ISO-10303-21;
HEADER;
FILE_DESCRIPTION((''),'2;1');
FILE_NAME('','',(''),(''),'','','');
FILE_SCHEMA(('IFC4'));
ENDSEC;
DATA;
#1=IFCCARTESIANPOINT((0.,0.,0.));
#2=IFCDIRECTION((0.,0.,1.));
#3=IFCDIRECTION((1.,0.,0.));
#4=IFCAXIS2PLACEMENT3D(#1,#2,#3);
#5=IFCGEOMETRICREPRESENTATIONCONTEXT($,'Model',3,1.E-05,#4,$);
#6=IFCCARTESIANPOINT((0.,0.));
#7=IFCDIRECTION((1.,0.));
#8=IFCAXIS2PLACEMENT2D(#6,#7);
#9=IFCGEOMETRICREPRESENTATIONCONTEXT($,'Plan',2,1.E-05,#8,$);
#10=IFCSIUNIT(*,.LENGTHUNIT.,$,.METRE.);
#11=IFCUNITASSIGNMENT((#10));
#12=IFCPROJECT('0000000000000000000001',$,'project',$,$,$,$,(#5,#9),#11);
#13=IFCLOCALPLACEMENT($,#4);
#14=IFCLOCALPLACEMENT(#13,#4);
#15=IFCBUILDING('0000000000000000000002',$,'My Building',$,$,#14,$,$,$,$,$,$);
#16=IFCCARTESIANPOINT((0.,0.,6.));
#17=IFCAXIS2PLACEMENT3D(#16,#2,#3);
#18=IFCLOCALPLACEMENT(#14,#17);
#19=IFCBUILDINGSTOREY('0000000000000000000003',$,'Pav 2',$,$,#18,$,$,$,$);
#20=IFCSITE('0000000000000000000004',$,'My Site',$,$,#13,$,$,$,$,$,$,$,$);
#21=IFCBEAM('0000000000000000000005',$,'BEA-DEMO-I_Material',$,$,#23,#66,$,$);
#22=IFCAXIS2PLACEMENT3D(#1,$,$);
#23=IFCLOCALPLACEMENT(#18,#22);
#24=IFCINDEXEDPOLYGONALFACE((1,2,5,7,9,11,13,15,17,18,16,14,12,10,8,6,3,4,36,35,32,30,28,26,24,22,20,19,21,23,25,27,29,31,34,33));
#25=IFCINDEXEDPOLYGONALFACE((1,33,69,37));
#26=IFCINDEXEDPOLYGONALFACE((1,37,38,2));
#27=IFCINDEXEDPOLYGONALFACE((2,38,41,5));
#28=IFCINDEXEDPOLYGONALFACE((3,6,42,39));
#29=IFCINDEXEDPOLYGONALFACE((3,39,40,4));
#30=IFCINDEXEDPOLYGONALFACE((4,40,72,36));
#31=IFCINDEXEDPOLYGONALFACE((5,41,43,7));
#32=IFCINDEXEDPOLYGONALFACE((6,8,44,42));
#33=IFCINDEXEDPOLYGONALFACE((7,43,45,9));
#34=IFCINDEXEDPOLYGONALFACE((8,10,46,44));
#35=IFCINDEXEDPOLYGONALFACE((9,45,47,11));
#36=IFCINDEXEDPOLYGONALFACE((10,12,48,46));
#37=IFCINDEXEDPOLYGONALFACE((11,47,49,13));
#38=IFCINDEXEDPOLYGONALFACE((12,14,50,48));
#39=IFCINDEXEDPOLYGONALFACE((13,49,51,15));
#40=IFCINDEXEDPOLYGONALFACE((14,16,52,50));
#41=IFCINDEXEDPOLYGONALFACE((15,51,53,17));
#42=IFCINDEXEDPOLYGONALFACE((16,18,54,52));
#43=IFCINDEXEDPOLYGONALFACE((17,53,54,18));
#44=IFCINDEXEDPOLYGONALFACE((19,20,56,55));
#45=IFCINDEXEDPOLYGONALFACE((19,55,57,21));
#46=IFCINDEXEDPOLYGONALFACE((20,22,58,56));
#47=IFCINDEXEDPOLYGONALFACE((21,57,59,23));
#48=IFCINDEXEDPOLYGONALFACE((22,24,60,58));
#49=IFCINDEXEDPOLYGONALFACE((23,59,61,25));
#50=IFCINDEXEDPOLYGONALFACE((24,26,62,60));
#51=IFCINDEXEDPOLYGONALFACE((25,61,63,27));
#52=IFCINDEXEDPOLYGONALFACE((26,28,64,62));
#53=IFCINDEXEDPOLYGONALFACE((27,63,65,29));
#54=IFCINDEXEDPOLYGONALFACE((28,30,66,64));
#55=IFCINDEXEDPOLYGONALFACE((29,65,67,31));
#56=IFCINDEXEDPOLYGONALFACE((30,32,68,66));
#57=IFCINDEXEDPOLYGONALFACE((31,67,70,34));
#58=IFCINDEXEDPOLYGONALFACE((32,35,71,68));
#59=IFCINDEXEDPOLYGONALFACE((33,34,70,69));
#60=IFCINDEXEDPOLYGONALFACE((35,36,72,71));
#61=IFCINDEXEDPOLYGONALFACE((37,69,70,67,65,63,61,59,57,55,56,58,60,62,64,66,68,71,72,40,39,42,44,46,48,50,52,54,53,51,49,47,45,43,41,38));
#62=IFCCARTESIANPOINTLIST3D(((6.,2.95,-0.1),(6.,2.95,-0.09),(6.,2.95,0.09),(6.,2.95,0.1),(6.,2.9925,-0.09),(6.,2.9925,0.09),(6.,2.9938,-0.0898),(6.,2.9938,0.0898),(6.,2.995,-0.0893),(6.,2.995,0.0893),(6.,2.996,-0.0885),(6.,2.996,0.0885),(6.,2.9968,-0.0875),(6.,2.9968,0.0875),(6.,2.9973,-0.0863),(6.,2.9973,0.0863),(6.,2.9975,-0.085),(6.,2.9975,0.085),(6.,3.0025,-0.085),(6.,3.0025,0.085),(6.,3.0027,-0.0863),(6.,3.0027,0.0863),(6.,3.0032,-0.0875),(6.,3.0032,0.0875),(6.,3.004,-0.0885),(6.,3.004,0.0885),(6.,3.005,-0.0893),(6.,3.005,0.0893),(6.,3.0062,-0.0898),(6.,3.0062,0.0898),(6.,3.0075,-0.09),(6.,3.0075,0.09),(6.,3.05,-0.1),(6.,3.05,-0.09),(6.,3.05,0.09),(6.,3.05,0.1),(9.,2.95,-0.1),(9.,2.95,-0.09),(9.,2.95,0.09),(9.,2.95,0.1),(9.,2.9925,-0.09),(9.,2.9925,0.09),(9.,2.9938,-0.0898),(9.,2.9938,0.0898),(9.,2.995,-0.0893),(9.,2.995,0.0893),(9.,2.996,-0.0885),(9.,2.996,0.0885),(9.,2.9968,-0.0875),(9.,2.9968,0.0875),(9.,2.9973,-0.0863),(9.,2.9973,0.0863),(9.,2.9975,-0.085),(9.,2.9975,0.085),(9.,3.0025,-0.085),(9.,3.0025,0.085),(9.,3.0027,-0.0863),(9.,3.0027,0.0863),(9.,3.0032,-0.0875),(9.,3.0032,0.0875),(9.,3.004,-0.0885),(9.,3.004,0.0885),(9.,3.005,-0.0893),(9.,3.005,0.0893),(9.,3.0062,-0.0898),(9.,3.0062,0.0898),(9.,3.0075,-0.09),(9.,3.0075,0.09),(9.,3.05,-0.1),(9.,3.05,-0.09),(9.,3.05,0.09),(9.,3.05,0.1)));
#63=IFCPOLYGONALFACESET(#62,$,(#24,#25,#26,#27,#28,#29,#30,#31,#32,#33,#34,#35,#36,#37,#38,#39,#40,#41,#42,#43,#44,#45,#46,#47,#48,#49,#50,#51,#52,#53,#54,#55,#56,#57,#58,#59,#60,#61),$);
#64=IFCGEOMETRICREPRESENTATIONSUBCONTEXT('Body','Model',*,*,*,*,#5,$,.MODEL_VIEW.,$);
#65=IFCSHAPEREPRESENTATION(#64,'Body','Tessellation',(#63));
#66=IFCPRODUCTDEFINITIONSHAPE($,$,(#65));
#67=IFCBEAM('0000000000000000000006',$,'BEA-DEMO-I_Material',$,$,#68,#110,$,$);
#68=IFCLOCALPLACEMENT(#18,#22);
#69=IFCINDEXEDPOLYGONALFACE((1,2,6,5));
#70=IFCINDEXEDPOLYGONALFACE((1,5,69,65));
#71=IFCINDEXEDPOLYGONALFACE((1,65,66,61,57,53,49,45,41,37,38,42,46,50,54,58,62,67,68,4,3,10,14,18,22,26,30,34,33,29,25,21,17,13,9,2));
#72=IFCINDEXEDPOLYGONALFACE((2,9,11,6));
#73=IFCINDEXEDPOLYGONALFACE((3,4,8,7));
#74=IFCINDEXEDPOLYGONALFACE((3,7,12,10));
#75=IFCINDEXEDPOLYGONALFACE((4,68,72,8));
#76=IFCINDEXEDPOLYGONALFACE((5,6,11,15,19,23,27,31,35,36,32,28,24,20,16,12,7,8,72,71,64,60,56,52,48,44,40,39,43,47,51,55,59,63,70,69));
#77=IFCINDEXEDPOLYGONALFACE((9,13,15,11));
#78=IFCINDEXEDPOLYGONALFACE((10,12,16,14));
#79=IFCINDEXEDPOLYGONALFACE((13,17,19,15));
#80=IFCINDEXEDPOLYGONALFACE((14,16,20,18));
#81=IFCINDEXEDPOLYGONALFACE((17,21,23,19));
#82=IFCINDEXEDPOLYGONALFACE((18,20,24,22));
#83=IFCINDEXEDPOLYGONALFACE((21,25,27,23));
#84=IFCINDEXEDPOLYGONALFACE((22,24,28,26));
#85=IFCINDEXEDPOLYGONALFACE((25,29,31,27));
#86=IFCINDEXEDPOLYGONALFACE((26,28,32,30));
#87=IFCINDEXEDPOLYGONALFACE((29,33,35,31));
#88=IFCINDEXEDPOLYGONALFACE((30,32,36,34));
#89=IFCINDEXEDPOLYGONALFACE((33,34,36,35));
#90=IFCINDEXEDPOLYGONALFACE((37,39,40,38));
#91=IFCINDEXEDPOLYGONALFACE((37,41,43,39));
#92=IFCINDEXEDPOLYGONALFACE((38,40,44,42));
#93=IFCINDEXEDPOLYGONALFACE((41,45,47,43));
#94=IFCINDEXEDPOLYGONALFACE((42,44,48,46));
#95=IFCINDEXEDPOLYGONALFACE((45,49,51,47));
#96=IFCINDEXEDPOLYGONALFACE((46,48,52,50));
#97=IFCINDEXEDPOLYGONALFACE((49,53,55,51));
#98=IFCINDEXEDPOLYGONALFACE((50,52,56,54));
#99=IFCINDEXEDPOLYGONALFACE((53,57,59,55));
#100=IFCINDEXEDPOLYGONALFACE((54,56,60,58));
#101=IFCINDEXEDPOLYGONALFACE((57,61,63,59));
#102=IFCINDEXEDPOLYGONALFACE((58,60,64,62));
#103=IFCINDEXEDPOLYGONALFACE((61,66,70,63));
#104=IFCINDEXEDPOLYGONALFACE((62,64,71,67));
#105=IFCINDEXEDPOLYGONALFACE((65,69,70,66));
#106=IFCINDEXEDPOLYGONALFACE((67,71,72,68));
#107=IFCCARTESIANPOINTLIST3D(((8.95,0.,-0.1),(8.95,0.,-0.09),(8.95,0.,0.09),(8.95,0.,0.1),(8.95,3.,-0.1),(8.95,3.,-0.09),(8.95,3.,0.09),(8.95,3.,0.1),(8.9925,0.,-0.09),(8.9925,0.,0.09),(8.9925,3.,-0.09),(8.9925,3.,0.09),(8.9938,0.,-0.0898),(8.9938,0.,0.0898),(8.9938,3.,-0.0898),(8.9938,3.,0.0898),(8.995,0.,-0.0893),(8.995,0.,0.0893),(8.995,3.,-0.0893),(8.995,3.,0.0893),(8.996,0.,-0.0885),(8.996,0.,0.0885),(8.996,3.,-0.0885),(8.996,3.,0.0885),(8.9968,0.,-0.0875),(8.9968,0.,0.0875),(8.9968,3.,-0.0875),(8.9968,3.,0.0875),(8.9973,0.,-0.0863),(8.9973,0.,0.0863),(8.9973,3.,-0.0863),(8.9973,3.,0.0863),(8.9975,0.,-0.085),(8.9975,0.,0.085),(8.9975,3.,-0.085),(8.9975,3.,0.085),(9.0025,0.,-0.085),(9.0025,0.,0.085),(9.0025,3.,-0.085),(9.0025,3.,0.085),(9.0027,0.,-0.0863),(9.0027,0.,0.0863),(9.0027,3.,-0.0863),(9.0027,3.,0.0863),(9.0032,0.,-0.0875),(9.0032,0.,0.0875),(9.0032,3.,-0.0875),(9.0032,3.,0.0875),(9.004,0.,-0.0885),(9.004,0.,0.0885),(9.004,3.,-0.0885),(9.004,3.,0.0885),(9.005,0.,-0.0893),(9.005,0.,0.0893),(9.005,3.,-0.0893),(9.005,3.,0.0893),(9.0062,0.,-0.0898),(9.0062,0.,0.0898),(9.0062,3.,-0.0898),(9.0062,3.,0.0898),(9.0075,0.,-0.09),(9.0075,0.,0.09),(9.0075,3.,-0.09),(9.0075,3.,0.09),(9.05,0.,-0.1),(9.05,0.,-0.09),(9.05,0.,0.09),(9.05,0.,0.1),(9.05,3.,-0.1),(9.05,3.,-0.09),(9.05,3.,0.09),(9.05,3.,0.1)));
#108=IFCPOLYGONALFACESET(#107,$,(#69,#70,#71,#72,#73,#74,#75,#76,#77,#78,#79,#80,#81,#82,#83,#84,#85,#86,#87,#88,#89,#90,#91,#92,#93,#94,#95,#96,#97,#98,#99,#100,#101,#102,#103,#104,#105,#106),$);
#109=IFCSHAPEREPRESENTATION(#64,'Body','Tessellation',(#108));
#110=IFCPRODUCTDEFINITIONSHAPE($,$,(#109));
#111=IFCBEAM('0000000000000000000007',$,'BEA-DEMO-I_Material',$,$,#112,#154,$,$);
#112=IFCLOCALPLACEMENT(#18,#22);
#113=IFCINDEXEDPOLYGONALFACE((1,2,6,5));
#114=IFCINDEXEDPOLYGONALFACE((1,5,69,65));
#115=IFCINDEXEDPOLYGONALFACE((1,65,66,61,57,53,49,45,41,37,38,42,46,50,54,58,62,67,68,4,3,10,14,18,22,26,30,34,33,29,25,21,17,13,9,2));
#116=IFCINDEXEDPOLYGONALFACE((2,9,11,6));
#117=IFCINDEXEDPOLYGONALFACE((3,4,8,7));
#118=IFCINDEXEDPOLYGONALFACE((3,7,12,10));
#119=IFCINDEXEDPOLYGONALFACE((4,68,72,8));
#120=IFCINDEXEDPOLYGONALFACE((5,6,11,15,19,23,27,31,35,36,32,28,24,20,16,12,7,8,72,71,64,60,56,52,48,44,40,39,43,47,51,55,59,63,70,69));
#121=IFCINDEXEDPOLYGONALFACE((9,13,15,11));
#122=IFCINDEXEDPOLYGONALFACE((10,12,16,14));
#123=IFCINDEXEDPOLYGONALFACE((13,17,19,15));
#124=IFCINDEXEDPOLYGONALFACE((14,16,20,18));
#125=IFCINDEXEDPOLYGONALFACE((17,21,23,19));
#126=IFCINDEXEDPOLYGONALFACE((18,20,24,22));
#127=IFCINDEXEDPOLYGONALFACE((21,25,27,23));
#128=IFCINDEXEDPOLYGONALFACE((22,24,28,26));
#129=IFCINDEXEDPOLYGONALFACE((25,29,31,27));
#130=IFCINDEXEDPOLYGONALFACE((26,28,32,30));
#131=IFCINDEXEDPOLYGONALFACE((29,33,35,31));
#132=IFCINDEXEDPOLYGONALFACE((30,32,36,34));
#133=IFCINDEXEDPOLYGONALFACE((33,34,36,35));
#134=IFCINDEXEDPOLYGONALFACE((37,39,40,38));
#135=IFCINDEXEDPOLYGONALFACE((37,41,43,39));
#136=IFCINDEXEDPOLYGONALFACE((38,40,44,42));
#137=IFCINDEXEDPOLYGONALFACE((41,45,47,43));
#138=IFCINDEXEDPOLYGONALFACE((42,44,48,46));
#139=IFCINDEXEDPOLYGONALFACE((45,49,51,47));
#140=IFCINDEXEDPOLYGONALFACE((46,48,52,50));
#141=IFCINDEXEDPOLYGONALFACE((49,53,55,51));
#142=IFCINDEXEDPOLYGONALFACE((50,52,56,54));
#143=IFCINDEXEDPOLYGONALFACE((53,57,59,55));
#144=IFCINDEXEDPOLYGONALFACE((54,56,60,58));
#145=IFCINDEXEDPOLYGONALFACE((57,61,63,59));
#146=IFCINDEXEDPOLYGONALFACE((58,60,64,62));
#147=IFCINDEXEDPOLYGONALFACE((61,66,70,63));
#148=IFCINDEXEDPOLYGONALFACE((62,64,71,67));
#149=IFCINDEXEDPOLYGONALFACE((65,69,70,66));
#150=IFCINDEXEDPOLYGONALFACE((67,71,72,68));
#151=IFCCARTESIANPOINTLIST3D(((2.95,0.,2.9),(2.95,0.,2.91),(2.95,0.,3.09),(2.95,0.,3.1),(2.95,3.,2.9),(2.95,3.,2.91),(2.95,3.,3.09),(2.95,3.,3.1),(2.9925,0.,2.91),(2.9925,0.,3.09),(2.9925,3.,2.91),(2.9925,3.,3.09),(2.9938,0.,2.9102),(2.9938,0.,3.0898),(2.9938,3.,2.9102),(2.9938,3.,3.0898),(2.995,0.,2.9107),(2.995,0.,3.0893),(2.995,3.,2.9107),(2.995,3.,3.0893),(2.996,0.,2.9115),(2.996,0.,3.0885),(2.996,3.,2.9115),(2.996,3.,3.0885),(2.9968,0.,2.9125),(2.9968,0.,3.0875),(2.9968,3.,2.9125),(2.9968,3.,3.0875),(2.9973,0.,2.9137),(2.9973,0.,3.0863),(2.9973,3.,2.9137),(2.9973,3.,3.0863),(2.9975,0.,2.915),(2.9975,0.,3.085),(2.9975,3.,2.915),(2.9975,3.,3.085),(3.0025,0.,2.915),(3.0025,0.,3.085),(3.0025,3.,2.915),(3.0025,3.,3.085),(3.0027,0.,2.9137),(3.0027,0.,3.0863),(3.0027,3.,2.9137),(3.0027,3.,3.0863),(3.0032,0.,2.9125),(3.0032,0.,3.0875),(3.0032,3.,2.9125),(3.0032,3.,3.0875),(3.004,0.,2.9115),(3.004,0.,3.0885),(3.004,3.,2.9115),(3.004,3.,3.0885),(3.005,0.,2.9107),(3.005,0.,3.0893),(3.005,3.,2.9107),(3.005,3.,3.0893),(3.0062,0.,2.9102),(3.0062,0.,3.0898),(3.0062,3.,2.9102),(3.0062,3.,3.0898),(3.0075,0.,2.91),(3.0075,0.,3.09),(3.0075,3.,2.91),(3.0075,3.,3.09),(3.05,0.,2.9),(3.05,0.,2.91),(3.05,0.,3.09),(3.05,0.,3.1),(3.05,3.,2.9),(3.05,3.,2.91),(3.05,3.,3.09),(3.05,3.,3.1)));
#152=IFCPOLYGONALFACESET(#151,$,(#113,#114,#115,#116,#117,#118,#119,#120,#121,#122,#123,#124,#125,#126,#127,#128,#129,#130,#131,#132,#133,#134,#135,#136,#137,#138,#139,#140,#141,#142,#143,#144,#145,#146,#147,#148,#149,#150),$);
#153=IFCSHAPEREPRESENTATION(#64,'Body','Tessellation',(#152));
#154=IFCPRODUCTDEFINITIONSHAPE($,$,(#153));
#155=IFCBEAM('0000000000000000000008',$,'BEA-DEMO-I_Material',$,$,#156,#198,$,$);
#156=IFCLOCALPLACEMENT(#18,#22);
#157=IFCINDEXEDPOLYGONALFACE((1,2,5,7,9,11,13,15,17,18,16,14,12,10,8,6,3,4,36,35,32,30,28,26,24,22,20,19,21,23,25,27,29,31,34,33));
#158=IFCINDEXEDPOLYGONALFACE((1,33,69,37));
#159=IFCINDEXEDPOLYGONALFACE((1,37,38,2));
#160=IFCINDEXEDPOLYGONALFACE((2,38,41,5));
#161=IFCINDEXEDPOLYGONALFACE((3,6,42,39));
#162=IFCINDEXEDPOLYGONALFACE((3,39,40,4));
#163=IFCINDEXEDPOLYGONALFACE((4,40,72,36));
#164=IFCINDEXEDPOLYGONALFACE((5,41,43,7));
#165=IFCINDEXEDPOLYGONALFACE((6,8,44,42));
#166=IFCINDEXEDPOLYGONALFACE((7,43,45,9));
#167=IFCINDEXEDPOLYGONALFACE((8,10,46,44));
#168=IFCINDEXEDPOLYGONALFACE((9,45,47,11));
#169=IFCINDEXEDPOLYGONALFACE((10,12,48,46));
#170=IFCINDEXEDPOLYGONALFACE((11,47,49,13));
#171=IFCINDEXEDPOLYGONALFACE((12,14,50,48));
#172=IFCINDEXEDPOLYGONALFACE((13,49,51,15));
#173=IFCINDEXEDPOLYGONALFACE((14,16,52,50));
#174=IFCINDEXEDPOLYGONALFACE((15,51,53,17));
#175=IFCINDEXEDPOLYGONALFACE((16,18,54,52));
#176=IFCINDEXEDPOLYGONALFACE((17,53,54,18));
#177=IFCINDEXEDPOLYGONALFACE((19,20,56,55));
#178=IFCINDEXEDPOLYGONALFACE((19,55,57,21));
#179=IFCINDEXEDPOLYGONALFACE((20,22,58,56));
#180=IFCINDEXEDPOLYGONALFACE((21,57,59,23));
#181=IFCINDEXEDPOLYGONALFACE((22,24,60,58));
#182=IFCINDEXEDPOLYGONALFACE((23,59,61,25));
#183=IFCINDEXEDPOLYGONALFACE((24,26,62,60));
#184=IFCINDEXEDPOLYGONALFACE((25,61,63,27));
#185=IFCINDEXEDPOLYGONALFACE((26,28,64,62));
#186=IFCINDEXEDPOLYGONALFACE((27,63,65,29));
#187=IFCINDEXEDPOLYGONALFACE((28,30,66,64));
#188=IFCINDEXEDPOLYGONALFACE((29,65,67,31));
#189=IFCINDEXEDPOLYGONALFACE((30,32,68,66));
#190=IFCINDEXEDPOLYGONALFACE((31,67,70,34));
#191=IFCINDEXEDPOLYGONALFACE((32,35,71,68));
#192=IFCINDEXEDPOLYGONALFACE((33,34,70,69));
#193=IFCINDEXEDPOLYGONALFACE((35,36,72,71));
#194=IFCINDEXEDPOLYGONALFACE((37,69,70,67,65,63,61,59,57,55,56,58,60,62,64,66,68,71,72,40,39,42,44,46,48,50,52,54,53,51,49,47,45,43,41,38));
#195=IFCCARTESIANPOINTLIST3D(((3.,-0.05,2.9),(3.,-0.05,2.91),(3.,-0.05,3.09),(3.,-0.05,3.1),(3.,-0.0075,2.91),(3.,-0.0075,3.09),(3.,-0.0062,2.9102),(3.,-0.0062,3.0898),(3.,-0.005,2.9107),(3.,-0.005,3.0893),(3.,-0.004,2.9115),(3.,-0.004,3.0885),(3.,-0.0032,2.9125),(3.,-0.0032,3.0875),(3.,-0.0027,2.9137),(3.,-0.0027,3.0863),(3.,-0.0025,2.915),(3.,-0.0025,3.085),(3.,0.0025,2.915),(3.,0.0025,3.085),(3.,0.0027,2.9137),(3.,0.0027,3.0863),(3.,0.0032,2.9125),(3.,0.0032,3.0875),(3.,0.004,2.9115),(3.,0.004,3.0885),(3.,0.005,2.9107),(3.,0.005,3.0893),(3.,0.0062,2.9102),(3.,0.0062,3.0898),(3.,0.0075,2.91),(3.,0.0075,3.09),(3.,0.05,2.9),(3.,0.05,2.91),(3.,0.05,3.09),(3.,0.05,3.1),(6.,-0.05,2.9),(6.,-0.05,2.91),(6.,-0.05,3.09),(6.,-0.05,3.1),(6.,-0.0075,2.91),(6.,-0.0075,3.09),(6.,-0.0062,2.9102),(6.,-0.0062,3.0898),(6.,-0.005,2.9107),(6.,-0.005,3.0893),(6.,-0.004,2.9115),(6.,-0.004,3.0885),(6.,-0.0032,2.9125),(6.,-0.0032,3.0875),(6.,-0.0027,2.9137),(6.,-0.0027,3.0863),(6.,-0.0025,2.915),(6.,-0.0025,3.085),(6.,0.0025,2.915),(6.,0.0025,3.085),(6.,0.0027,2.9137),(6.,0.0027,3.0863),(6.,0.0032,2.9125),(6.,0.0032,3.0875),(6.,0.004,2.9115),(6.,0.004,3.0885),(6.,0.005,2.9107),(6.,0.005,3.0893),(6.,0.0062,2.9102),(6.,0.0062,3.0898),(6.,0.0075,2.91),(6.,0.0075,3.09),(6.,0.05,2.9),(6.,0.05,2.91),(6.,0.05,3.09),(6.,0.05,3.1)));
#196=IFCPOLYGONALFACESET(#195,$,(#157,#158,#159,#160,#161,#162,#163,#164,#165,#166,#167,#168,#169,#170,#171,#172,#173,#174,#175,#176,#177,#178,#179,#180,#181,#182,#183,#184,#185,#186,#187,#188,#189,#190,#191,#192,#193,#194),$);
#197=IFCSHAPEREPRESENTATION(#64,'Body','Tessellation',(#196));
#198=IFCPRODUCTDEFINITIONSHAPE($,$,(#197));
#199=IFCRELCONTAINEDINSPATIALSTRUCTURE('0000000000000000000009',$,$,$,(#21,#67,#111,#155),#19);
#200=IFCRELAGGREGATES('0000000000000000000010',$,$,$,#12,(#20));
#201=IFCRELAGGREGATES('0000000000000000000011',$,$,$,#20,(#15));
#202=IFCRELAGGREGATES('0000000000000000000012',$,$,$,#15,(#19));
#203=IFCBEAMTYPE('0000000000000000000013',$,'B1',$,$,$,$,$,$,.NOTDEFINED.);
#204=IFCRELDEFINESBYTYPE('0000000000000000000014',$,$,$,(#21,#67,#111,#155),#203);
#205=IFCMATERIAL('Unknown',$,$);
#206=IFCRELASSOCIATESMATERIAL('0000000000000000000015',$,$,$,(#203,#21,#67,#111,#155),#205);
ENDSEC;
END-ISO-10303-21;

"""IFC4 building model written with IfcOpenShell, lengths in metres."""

from ifc_helpers import new_model, si_unit, frame, origin, origin_with_axes, origin_2d_with_axis, place, context, subcontext, project, spatial, i_section, extrude, material, material_profile, profile_set, profile_usage, type_object, element, save


model = new_model("IFC4")

# Units and contexts
model_context = context("Model", 3, precision=1e-05, world=origin_with_axes())
plan_context = context("Plan", 2, precision=1e-05, world=origin_2d_with_axis())
body_context = subcontext(model_context, "Body", "Model", "MODEL_VIEW")
ifc_project = project(units=[si_unit("LENGTHUNIT", "METRE")], contexts=[model_context, plan_context])

# Site, building, storey
site_placement = place(None, origin_with_axes())
site = spatial("IfcSite", under=ifc_project, at=site_placement, Name="My Site")
building_placement = place(site_placement, origin_with_axes())
building = spatial("IfcBuilding", under=site, at=building_placement, Name="My Building")
storey_placement = place(building_placement, frame((0.0, 0.0, 6.0), z_axis=(0.0, 0.0, 1.0), x_axis=(1.0, 0.0, 0.0)))
storey = spatial("IfcBuildingStorey", under=building, at=storey_placement, Name="Pav 2")

# Beams
ifc_material = material(Name="Unknown")
ifc_material_profile = material_profile(ifc_material, i_section(OverallWidth=0.1, OverallDepth=0.2, WebThickness=0.005, FlangeThickness=0.01, FilletRadius=0.005))
ifc_profile_set = profile_set([ifc_material_profile])
beam_type = type_object("IfcBeamType", Name="B1", PredefinedType="NOTDEFINED", material=ifc_profile_set)
ifc_profile_usage_1 = profile_usage(ifc_profile_set, cardinal=5)
beam_1_placement = place(storey_placement, frame((6.0, 3.0, 0.0), z_axis=(1.0, 0.0, 0.0), x_axis=(0.0, 1.0, 0.0)))
element("IfcBeam", 1, at=beam_1_placement, inside=storey, type_object=beam_type, material=ifc_profile_usage_1, Name="BEA-DEMO-I_Material", context=body_context, shape_type="SweptSolid", body=[
    extrude(i_section(OverallWidth=0.1, OverallDepth=0.2, WebThickness=0.005, FlangeThickness=0.01, FilletRadius=0.005), origin(), (0.0, 0.0, 1.0), 3.0),
])
ifc_profile_usage_2 = profile_usage(ifc_profile_set, cardinal=5)
beam_2_placement = place(storey_placement, frame((9.0, 3.0, 0.0), z_axis=(0.0, -1.0, 0.0), x_axis=(1.0, 0.0, 0.0)))
element("IfcBeam", 2, at=beam_2_placement, inside=storey, type_object=beam_type, material=ifc_profile_usage_2, Name="BEA-DEMO-I_Material", context=body_context, shape_type="SweptSolid", body=[
    extrude(i_section(OverallWidth=0.1, OverallDepth=0.2, WebThickness=0.005, FlangeThickness=0.01, FilletRadius=0.005), origin(), (0.0, 0.0, 1.0), 3.0),
])
ifc_profile_usage_3 = profile_usage(ifc_profile_set, cardinal=5)
beam_3_placement = place(storey_placement, frame((3.0, 3.0, 3.0), z_axis=(0.0, -1.0, 0.0), x_axis=(1.0, 0.0, 0.0)))
element("IfcBeam", 3, at=beam_3_placement, inside=storey, type_object=beam_type, material=ifc_profile_usage_3, Name="BEA-DEMO-I_Material", context=body_context, shape_type="SweptSolid", body=[
    extrude(i_section(OverallWidth=0.1, OverallDepth=0.2, WebThickness=0.005, FlangeThickness=0.01, FilletRadius=0.005), origin(), (0.0, 0.0, 1.0), 3.0),
])
ifc_profile_usage_4 = profile_usage(ifc_profile_set, cardinal=5)
beam_4_placement = place(storey_placement, frame((6.0, 0.0, 3.0), z_axis=(-1.0, 0.0, 0.0), x_axis=(0.0, -1.0, 0.0)))
element("IfcBeam", 4, at=beam_4_placement, inside=storey, type_object=beam_type, material=ifc_profile_usage_4, Name="BEA-DEMO-I_Material", context=body_context, shape_type="SweptSolid", body=[
    extrude(i_section(OverallWidth=0.1, OverallDepth=0.2, WebThickness=0.005, FlangeThickness=0.01, FilletRadius=0.005), origin(), (0.0, 0.0, 1.0), 3.0),
])

save(model, "model.ifc")
